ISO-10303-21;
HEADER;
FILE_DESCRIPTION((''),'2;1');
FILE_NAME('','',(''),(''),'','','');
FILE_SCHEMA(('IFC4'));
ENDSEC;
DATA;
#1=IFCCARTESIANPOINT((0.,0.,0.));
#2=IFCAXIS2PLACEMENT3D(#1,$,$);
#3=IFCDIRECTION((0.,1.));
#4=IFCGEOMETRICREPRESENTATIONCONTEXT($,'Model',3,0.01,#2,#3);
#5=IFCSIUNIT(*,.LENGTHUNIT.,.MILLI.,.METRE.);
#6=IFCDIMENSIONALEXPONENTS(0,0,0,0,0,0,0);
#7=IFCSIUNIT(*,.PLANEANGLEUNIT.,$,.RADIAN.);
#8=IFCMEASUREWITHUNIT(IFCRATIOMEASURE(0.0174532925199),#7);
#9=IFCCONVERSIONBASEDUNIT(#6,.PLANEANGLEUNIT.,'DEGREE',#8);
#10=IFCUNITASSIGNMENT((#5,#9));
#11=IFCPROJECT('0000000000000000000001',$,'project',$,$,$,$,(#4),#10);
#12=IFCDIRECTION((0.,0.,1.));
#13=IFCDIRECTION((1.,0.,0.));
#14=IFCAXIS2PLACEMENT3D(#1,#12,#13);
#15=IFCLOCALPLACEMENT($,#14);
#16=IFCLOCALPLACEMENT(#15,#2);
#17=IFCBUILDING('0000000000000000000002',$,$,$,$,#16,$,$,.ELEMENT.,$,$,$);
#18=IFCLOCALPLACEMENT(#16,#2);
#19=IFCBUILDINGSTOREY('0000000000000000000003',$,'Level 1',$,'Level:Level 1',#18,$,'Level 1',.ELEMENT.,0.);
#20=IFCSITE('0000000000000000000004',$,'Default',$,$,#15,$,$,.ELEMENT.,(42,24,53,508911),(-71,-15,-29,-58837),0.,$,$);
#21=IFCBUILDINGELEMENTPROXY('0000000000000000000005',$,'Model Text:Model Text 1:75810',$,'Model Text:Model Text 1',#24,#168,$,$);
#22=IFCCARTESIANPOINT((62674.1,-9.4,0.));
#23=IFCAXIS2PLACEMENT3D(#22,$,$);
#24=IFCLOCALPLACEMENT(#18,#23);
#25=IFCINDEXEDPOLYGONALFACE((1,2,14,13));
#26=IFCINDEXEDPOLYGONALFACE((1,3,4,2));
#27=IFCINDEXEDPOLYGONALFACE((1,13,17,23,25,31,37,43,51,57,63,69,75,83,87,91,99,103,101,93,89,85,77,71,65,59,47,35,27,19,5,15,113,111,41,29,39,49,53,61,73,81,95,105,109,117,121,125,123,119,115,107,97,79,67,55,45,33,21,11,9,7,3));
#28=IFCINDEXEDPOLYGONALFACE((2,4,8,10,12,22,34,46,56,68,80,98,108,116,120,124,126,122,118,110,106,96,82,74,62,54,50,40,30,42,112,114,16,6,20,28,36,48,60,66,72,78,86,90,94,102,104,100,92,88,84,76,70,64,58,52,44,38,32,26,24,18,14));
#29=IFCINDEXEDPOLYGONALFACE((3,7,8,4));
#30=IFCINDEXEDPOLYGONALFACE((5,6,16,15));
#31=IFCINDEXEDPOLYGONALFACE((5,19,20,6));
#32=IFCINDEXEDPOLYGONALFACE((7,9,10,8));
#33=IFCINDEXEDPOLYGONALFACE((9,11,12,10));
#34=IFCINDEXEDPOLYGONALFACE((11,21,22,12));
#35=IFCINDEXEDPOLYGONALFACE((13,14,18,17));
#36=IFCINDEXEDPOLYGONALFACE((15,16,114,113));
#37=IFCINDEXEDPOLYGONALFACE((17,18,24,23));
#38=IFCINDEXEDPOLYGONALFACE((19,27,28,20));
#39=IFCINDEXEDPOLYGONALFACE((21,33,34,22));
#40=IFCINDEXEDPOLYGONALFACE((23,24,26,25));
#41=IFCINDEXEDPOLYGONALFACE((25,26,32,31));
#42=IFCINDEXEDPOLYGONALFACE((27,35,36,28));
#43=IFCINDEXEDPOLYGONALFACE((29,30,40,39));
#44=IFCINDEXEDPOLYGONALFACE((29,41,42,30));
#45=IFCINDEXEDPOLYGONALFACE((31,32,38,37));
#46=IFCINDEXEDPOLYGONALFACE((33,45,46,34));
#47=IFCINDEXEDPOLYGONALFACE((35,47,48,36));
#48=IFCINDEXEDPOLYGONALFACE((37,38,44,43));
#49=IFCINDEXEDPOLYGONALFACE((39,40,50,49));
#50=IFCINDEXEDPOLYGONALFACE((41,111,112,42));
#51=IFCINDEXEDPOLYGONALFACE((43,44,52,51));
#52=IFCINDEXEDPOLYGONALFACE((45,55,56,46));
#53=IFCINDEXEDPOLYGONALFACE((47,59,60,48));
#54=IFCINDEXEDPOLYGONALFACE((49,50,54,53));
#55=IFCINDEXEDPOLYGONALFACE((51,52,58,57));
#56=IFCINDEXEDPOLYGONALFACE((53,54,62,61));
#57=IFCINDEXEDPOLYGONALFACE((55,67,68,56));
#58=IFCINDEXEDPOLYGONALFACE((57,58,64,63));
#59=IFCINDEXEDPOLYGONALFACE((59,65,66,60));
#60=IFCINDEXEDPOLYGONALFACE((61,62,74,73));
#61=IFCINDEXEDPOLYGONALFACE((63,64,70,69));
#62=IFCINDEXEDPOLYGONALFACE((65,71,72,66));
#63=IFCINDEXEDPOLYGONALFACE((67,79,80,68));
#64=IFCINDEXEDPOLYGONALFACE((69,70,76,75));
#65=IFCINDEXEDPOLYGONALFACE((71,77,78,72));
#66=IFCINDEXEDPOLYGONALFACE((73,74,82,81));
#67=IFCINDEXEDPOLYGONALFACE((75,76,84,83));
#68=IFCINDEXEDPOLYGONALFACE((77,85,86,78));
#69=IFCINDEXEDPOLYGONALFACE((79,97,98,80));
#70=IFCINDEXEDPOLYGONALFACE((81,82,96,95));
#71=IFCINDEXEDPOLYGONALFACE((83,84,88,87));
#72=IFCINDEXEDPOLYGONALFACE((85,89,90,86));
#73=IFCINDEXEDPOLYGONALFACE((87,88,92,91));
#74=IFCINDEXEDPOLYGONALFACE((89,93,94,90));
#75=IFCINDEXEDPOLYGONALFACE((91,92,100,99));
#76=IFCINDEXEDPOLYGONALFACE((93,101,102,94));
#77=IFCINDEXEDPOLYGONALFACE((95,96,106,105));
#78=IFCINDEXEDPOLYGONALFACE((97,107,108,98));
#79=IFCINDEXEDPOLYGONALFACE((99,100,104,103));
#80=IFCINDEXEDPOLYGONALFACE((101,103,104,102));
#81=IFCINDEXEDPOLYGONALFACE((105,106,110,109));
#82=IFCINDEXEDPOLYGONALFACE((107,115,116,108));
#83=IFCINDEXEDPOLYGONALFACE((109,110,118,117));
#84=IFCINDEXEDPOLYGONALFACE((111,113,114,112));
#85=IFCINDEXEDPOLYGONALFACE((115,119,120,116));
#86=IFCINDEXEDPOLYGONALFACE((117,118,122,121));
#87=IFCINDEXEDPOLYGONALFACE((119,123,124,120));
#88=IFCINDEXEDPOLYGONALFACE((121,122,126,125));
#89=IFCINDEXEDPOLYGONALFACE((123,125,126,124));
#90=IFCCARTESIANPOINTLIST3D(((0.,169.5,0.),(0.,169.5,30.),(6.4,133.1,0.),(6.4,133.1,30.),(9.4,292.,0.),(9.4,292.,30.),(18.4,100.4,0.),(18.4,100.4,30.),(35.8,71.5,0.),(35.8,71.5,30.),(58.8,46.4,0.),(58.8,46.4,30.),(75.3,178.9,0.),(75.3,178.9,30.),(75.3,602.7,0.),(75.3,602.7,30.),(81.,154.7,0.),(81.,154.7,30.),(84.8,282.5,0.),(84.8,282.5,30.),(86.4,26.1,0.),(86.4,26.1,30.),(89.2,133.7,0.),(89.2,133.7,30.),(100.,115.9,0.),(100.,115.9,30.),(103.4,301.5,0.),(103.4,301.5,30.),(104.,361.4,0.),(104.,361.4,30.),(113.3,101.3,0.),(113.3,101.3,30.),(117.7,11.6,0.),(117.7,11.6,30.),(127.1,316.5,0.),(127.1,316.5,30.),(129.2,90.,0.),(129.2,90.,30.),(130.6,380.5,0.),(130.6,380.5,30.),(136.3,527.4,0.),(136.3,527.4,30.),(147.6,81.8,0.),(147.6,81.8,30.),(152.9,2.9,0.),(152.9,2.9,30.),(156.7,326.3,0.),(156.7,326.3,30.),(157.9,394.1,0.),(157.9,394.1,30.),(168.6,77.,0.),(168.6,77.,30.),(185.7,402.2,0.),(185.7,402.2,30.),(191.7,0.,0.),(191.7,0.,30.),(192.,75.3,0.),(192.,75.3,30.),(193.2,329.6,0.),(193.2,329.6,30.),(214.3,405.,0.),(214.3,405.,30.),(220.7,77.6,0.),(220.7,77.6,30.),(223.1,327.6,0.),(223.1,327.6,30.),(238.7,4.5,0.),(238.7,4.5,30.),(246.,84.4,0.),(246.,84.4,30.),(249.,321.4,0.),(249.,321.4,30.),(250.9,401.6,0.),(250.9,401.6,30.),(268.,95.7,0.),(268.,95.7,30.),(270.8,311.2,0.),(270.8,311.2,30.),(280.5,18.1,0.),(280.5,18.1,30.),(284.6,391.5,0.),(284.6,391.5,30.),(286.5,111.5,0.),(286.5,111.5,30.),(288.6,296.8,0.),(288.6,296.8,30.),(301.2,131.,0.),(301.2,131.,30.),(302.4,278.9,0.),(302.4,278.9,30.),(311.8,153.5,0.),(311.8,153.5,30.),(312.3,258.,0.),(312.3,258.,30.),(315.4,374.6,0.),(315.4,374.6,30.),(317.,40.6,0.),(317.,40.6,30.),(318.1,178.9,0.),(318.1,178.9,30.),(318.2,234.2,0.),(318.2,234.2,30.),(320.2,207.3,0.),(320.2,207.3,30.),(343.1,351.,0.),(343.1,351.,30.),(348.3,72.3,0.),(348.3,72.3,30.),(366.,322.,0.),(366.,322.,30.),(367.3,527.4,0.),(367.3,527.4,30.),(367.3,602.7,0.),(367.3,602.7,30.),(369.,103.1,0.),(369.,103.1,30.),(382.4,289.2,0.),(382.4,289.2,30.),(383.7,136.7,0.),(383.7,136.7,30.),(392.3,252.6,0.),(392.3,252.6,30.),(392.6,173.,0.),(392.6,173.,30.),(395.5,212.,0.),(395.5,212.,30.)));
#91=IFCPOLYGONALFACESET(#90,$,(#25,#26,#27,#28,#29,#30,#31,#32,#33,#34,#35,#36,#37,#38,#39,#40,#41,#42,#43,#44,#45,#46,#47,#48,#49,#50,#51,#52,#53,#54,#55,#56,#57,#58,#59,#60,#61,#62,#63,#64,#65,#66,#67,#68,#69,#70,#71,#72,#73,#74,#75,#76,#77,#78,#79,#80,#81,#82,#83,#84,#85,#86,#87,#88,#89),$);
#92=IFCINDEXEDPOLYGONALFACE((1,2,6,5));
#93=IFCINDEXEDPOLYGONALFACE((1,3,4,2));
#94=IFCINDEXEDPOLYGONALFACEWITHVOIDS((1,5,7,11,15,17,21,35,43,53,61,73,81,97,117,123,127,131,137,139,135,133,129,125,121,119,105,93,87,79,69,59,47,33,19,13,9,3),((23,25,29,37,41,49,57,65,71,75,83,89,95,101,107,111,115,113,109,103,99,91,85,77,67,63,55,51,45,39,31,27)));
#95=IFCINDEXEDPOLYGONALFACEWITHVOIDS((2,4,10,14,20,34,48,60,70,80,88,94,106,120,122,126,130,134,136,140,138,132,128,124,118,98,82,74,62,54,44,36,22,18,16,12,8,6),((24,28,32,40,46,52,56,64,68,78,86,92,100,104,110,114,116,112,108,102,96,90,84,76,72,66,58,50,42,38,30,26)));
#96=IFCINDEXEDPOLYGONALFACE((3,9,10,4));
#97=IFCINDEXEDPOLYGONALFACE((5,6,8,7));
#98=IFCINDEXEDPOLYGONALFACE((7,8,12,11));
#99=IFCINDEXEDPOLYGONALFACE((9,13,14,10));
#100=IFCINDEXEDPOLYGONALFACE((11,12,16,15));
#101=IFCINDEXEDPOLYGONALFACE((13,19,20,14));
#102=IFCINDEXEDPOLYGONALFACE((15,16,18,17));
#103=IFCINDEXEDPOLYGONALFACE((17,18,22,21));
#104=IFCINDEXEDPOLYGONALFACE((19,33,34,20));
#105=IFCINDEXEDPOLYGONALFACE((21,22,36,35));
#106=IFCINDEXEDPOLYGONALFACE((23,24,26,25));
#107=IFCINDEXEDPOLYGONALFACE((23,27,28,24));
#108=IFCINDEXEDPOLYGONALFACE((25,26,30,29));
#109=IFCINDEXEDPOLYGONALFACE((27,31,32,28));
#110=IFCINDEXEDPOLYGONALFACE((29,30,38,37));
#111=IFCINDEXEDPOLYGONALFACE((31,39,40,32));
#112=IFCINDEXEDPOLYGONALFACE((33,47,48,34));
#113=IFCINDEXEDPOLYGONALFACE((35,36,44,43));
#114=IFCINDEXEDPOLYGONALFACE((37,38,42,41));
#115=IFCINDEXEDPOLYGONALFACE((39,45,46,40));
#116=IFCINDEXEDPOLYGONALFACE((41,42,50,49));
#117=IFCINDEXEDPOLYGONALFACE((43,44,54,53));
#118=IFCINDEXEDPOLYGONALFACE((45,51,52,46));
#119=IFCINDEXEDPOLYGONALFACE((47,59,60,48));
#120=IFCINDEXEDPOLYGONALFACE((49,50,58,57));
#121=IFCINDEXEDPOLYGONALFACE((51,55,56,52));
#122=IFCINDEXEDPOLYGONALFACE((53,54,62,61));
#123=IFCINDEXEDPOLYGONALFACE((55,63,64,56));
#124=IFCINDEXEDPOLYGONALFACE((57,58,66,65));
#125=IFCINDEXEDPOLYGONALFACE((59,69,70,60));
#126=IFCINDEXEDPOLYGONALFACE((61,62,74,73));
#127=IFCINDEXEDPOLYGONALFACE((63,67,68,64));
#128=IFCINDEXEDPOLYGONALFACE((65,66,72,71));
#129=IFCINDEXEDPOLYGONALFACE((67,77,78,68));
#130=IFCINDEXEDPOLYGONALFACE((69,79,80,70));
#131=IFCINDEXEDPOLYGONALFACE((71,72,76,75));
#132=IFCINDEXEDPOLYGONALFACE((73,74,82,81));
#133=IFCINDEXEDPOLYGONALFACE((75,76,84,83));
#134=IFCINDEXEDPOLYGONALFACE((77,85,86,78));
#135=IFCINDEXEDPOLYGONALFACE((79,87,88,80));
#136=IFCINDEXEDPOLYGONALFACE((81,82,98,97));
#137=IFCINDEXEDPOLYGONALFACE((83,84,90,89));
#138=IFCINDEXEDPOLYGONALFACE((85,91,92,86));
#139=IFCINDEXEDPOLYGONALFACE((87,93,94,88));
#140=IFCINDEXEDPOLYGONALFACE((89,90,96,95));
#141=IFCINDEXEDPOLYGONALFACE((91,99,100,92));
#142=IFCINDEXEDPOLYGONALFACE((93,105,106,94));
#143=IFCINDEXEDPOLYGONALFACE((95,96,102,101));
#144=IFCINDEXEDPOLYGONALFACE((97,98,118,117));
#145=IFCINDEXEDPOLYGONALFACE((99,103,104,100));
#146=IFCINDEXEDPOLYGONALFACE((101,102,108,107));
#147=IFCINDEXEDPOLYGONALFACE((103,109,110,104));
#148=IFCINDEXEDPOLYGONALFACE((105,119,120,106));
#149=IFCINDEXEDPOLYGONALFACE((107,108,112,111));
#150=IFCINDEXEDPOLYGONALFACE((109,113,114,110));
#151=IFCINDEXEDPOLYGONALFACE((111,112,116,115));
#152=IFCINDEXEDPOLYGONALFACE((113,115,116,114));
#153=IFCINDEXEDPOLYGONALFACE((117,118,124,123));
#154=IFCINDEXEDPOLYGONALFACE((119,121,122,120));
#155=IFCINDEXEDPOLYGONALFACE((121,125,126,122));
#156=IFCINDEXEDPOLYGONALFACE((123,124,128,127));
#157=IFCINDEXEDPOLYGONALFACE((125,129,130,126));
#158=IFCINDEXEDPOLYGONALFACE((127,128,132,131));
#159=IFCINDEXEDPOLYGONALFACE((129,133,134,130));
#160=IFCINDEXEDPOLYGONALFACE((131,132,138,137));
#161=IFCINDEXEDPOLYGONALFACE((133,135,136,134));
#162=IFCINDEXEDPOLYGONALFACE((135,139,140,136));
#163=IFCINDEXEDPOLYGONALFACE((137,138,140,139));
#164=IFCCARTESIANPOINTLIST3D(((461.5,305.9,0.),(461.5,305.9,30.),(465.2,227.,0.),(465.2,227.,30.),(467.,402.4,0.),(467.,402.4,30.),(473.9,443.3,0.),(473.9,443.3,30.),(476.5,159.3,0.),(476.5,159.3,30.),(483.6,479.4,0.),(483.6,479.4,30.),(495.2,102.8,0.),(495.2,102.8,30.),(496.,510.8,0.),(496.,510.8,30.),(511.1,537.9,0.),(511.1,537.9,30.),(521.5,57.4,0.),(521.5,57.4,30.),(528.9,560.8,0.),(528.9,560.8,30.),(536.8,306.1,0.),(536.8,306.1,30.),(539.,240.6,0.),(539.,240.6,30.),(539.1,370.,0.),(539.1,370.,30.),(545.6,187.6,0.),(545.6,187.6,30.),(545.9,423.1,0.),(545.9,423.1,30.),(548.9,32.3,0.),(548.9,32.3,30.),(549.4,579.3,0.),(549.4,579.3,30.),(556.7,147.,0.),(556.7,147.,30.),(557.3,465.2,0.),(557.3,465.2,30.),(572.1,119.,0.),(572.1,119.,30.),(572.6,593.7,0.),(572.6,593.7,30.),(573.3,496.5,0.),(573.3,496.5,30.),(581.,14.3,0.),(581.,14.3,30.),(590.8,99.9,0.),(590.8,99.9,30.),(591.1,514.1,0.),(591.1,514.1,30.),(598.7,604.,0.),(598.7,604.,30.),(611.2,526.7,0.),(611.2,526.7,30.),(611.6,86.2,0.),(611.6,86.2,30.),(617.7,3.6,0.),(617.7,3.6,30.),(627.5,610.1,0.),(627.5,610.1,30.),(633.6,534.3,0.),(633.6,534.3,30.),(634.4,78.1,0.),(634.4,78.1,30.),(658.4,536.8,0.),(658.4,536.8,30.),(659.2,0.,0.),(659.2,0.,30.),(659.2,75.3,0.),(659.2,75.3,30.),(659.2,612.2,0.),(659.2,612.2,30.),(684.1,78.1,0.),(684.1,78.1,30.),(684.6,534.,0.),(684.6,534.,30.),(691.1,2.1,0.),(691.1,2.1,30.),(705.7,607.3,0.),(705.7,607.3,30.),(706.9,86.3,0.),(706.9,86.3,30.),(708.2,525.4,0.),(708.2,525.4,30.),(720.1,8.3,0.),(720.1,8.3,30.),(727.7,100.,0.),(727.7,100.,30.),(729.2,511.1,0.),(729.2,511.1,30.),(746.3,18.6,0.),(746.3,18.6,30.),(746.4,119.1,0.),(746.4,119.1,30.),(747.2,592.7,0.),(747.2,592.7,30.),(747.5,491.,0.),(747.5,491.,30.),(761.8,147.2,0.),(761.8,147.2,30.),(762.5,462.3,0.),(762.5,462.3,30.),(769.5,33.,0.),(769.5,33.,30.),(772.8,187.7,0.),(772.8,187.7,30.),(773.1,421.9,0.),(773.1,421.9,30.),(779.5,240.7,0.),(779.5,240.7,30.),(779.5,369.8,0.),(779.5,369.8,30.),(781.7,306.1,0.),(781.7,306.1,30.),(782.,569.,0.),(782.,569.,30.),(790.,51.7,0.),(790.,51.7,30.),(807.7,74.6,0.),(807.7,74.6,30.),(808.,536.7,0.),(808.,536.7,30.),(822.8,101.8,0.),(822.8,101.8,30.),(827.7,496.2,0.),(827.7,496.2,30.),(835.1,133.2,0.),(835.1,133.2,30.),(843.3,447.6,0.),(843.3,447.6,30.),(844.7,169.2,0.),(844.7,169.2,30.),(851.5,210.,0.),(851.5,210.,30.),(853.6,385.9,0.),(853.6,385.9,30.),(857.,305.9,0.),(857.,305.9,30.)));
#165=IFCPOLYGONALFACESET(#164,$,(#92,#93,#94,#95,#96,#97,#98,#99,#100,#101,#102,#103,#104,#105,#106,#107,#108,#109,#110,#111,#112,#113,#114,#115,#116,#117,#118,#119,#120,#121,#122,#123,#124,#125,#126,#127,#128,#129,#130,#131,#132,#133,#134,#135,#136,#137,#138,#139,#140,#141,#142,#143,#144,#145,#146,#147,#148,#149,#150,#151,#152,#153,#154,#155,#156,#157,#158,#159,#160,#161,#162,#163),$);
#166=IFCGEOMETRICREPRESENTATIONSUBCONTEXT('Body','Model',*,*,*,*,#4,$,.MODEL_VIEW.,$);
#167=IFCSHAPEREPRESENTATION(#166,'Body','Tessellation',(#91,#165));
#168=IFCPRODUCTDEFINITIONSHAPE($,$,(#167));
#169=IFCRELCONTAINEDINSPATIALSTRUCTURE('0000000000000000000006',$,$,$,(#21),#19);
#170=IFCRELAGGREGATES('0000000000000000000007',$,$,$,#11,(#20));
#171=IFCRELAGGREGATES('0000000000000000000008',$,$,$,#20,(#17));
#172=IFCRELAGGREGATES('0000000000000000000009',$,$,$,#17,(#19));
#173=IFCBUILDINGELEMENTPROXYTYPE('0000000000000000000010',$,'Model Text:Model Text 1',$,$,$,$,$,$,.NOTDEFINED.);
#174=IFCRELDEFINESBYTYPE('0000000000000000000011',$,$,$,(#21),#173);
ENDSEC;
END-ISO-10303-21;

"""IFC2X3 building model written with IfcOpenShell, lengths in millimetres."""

from ifc_helpers import new_model, entity, si_unit, converted_unit, direction, frame, origin, origin_with_axes, place, context, subcontext, project, spatial, polyline, outline, extrude, type_object, element, save


model = new_model("IFC2X3")

# Units and contexts
model_context = context("Model", 3, precision=0.01, world=origin(), true_north=direction((0.0, 1.0)))
body_context = subcontext(model_context, "Body", "Model", "MODEL_VIEW")
ifc_project = project(units=[si_unit("LENGTHUNIT", "METRE", prefix="MILLI"), converted_unit("PLANEANGLEUNIT", "DEGREE", entity("IfcRatioMeasure", 0.0174532925199), si_unit("PLANEANGLEUNIT", "RADIAN"), dimensions=[0, 0, 0, 0, 0, 0, 0])], contexts=[model_context])

# Site, building, storey
site_placement = place(None, origin_with_axes())
site = spatial("IfcSite", under=ifc_project, at=site_placement, Name="Default", CompositionType="ELEMENT", RefLatitude=(42, 24, 53, 508911), RefLongitude=(-71, -15, -29, -58837), RefElevation=0.0)
building_placement = place(site_placement, origin())
building = spatial("IfcBuilding", under=site, at=building_placement, CompositionType="ELEMENT")
storey_placement = place(building_placement, origin())
storey = spatial("IfcBuildingStorey", under=building, at=storey_placement, Name="Level 1", ObjectType="Level:Level 1", LongName="Level 1", CompositionType="ELEMENT", Elevation=0.0)

# Building element proxy
building_element_proxy_type_1 = type_object("IfcBuildingElementProxyType", Name="Model Text:Model Text 1", PredefinedType="NOTDEFINED")
proxy_1_placement = place(storey_placement, frame((62674.1, -9.4, 0.0)))
element("IfcBuildingElementProxy", 1, at=proxy_1_placement, inside=storey, type_object=building_element_proxy_type_1, Name="Model Text:Model Text 1:75810", ObjectType="Model Text:Model Text 1", context=body_context, shape_type="SweptSolid", body=[
    extrude(outline(polyline([(12.1, -219.3), (49.1, -219.3), (83.4, -213.2), (114.8, -201.1), (143.5, -182.8), (168.3, -159.2), (188.1, -130.8), (202.8, -97.8), (212.4, -60.0), (216.1, -12.9), (210.0, 30.5), (194.1, 70.4), (168.4, 106.8), (141.6, 132.5), (111.1, 152.9), (76.9, 167.9), (39.0, 177.6), (-1.5, 181.4), (-39.3, 178.1), (-74.4, 167.6), (-106.9, 150.1), (-135.0, 126.9), (-157.0, 99.6), (-172.8, 68.1), (-182.5, 32.6), (-184.8, 4.0), (-181.6, -24.8), (-172.9, -54.0), (-158.8, -83.5), (-316.6, -22.9), (-276.5, 204.6), (-350.7, 217.7), (-401.4, -69.8), (-106.8, -188.8), (-84.5, -116.2), (-99.9, -94.5), (-110.6, -68.6), (-115.1, -37.8), (-112.0, -1.2), (-104.8, 27.9), (-94.2, 52.3), (-80.3, 72.0), (-63.1, 87.0), (-43.0, 97.5), (-20.8, 103.6), (3.8, 105.3), (30.5, 102.6), (58.1, 95.6), (82.1, 84.9), (102.4, 70.6), (119.1, 52.7), (131.4, 31.7), (138.7, 8.2), (141.0, -17.9), (138.2, -46.6), (132.6, -69.4), (124.1, -89.2), (112.9, -105.9), (99.0, -119.6), (82.3, -130.2), (62.9, -137.7), (40.8, -142.2), (15.9, -143.5), (12.1, -219.3)])), frame((213.9, 219.6, 0.0), z_axis=(0.0, 0.0, 1.0), x_axis=(0.173842, -0.984774, 0.0)), (0.0, 0.0, 1.0), 30.0),
    extrude(outline(polyline([(-10.6, -198.7), (68.3, -198.7), (136.5, -190.7), (193.9, -174.7), (240.5, -150.6), (266.9, -124.4), (286.3, -93.2), (298.8, -57.0), (304.3, -15.7), (303.8, 16.2), (299.0, 45.5), (289.9, 72.1), (276.6, 96.0), (258.9, 117.3), (236.9, 136.2), (210.4, 152.5), (179.6, 166.3), (144.1, 177.6), (103.7, 186.3), (8.2, 196.4), (-71.8, 196.7), (-134.0, 189.4), (-183.3, 176.1), (-224.7, 158.4), (-258.2, 133.9), (-283.5, 100.3), (-300.1, 59.5), (-307.1, 13.4), (-306.6, -18.4), (-301.8, -47.5), (-292.8, -74.0), (-279.6, -97.9), (-262.0, -119.2), (-240.0, -138.1), (-213.6, -154.5), (-182.8, -168.4), (-147.3, -179.8), (-106.7, -188.6), (-10.6, -198.7)]), holes=[polyline([(-7.2, -123.5), (-71.0, -118.2), (-123.6, -108.8), (-165.2, -95.4), (-195.7, -78.0), (-212.4, -59.4), (-224.1, -38.7), (-230.6, -15.9), (-231.9, 8.9), (-227.8, 35.0), (-218.1, 58.1), (-202.8, 78.4), (-182.0, 95.8), (-152.6, 109.4), (-111.7, 118.1), (-59.4, 122.0), (4.4, 121.1), (69.6, 115.8), (122.2, 106.7), (162.2, 93.7), (189.5, 77.0), (207.7, 57.4), (220.4, 36.0), (227.5, 12.8), (229.1, -12.1), (225.2, -36.8), (215.9, -59.2), (201.3, -79.3), (181.4, -97.1), (152.6, -111.2), (111.6, -120.3), (58.3, -124.4), (-7.2, -123.5)])]), frame((660.5, 304.7, 0.0), z_axis=(0.0, 0.0, 1.0), x_axis=(0.047515, -0.998871, 0.0)), (0.0, 0.0, 1.0), 30.0),
])

save(model, "model.ifc")
